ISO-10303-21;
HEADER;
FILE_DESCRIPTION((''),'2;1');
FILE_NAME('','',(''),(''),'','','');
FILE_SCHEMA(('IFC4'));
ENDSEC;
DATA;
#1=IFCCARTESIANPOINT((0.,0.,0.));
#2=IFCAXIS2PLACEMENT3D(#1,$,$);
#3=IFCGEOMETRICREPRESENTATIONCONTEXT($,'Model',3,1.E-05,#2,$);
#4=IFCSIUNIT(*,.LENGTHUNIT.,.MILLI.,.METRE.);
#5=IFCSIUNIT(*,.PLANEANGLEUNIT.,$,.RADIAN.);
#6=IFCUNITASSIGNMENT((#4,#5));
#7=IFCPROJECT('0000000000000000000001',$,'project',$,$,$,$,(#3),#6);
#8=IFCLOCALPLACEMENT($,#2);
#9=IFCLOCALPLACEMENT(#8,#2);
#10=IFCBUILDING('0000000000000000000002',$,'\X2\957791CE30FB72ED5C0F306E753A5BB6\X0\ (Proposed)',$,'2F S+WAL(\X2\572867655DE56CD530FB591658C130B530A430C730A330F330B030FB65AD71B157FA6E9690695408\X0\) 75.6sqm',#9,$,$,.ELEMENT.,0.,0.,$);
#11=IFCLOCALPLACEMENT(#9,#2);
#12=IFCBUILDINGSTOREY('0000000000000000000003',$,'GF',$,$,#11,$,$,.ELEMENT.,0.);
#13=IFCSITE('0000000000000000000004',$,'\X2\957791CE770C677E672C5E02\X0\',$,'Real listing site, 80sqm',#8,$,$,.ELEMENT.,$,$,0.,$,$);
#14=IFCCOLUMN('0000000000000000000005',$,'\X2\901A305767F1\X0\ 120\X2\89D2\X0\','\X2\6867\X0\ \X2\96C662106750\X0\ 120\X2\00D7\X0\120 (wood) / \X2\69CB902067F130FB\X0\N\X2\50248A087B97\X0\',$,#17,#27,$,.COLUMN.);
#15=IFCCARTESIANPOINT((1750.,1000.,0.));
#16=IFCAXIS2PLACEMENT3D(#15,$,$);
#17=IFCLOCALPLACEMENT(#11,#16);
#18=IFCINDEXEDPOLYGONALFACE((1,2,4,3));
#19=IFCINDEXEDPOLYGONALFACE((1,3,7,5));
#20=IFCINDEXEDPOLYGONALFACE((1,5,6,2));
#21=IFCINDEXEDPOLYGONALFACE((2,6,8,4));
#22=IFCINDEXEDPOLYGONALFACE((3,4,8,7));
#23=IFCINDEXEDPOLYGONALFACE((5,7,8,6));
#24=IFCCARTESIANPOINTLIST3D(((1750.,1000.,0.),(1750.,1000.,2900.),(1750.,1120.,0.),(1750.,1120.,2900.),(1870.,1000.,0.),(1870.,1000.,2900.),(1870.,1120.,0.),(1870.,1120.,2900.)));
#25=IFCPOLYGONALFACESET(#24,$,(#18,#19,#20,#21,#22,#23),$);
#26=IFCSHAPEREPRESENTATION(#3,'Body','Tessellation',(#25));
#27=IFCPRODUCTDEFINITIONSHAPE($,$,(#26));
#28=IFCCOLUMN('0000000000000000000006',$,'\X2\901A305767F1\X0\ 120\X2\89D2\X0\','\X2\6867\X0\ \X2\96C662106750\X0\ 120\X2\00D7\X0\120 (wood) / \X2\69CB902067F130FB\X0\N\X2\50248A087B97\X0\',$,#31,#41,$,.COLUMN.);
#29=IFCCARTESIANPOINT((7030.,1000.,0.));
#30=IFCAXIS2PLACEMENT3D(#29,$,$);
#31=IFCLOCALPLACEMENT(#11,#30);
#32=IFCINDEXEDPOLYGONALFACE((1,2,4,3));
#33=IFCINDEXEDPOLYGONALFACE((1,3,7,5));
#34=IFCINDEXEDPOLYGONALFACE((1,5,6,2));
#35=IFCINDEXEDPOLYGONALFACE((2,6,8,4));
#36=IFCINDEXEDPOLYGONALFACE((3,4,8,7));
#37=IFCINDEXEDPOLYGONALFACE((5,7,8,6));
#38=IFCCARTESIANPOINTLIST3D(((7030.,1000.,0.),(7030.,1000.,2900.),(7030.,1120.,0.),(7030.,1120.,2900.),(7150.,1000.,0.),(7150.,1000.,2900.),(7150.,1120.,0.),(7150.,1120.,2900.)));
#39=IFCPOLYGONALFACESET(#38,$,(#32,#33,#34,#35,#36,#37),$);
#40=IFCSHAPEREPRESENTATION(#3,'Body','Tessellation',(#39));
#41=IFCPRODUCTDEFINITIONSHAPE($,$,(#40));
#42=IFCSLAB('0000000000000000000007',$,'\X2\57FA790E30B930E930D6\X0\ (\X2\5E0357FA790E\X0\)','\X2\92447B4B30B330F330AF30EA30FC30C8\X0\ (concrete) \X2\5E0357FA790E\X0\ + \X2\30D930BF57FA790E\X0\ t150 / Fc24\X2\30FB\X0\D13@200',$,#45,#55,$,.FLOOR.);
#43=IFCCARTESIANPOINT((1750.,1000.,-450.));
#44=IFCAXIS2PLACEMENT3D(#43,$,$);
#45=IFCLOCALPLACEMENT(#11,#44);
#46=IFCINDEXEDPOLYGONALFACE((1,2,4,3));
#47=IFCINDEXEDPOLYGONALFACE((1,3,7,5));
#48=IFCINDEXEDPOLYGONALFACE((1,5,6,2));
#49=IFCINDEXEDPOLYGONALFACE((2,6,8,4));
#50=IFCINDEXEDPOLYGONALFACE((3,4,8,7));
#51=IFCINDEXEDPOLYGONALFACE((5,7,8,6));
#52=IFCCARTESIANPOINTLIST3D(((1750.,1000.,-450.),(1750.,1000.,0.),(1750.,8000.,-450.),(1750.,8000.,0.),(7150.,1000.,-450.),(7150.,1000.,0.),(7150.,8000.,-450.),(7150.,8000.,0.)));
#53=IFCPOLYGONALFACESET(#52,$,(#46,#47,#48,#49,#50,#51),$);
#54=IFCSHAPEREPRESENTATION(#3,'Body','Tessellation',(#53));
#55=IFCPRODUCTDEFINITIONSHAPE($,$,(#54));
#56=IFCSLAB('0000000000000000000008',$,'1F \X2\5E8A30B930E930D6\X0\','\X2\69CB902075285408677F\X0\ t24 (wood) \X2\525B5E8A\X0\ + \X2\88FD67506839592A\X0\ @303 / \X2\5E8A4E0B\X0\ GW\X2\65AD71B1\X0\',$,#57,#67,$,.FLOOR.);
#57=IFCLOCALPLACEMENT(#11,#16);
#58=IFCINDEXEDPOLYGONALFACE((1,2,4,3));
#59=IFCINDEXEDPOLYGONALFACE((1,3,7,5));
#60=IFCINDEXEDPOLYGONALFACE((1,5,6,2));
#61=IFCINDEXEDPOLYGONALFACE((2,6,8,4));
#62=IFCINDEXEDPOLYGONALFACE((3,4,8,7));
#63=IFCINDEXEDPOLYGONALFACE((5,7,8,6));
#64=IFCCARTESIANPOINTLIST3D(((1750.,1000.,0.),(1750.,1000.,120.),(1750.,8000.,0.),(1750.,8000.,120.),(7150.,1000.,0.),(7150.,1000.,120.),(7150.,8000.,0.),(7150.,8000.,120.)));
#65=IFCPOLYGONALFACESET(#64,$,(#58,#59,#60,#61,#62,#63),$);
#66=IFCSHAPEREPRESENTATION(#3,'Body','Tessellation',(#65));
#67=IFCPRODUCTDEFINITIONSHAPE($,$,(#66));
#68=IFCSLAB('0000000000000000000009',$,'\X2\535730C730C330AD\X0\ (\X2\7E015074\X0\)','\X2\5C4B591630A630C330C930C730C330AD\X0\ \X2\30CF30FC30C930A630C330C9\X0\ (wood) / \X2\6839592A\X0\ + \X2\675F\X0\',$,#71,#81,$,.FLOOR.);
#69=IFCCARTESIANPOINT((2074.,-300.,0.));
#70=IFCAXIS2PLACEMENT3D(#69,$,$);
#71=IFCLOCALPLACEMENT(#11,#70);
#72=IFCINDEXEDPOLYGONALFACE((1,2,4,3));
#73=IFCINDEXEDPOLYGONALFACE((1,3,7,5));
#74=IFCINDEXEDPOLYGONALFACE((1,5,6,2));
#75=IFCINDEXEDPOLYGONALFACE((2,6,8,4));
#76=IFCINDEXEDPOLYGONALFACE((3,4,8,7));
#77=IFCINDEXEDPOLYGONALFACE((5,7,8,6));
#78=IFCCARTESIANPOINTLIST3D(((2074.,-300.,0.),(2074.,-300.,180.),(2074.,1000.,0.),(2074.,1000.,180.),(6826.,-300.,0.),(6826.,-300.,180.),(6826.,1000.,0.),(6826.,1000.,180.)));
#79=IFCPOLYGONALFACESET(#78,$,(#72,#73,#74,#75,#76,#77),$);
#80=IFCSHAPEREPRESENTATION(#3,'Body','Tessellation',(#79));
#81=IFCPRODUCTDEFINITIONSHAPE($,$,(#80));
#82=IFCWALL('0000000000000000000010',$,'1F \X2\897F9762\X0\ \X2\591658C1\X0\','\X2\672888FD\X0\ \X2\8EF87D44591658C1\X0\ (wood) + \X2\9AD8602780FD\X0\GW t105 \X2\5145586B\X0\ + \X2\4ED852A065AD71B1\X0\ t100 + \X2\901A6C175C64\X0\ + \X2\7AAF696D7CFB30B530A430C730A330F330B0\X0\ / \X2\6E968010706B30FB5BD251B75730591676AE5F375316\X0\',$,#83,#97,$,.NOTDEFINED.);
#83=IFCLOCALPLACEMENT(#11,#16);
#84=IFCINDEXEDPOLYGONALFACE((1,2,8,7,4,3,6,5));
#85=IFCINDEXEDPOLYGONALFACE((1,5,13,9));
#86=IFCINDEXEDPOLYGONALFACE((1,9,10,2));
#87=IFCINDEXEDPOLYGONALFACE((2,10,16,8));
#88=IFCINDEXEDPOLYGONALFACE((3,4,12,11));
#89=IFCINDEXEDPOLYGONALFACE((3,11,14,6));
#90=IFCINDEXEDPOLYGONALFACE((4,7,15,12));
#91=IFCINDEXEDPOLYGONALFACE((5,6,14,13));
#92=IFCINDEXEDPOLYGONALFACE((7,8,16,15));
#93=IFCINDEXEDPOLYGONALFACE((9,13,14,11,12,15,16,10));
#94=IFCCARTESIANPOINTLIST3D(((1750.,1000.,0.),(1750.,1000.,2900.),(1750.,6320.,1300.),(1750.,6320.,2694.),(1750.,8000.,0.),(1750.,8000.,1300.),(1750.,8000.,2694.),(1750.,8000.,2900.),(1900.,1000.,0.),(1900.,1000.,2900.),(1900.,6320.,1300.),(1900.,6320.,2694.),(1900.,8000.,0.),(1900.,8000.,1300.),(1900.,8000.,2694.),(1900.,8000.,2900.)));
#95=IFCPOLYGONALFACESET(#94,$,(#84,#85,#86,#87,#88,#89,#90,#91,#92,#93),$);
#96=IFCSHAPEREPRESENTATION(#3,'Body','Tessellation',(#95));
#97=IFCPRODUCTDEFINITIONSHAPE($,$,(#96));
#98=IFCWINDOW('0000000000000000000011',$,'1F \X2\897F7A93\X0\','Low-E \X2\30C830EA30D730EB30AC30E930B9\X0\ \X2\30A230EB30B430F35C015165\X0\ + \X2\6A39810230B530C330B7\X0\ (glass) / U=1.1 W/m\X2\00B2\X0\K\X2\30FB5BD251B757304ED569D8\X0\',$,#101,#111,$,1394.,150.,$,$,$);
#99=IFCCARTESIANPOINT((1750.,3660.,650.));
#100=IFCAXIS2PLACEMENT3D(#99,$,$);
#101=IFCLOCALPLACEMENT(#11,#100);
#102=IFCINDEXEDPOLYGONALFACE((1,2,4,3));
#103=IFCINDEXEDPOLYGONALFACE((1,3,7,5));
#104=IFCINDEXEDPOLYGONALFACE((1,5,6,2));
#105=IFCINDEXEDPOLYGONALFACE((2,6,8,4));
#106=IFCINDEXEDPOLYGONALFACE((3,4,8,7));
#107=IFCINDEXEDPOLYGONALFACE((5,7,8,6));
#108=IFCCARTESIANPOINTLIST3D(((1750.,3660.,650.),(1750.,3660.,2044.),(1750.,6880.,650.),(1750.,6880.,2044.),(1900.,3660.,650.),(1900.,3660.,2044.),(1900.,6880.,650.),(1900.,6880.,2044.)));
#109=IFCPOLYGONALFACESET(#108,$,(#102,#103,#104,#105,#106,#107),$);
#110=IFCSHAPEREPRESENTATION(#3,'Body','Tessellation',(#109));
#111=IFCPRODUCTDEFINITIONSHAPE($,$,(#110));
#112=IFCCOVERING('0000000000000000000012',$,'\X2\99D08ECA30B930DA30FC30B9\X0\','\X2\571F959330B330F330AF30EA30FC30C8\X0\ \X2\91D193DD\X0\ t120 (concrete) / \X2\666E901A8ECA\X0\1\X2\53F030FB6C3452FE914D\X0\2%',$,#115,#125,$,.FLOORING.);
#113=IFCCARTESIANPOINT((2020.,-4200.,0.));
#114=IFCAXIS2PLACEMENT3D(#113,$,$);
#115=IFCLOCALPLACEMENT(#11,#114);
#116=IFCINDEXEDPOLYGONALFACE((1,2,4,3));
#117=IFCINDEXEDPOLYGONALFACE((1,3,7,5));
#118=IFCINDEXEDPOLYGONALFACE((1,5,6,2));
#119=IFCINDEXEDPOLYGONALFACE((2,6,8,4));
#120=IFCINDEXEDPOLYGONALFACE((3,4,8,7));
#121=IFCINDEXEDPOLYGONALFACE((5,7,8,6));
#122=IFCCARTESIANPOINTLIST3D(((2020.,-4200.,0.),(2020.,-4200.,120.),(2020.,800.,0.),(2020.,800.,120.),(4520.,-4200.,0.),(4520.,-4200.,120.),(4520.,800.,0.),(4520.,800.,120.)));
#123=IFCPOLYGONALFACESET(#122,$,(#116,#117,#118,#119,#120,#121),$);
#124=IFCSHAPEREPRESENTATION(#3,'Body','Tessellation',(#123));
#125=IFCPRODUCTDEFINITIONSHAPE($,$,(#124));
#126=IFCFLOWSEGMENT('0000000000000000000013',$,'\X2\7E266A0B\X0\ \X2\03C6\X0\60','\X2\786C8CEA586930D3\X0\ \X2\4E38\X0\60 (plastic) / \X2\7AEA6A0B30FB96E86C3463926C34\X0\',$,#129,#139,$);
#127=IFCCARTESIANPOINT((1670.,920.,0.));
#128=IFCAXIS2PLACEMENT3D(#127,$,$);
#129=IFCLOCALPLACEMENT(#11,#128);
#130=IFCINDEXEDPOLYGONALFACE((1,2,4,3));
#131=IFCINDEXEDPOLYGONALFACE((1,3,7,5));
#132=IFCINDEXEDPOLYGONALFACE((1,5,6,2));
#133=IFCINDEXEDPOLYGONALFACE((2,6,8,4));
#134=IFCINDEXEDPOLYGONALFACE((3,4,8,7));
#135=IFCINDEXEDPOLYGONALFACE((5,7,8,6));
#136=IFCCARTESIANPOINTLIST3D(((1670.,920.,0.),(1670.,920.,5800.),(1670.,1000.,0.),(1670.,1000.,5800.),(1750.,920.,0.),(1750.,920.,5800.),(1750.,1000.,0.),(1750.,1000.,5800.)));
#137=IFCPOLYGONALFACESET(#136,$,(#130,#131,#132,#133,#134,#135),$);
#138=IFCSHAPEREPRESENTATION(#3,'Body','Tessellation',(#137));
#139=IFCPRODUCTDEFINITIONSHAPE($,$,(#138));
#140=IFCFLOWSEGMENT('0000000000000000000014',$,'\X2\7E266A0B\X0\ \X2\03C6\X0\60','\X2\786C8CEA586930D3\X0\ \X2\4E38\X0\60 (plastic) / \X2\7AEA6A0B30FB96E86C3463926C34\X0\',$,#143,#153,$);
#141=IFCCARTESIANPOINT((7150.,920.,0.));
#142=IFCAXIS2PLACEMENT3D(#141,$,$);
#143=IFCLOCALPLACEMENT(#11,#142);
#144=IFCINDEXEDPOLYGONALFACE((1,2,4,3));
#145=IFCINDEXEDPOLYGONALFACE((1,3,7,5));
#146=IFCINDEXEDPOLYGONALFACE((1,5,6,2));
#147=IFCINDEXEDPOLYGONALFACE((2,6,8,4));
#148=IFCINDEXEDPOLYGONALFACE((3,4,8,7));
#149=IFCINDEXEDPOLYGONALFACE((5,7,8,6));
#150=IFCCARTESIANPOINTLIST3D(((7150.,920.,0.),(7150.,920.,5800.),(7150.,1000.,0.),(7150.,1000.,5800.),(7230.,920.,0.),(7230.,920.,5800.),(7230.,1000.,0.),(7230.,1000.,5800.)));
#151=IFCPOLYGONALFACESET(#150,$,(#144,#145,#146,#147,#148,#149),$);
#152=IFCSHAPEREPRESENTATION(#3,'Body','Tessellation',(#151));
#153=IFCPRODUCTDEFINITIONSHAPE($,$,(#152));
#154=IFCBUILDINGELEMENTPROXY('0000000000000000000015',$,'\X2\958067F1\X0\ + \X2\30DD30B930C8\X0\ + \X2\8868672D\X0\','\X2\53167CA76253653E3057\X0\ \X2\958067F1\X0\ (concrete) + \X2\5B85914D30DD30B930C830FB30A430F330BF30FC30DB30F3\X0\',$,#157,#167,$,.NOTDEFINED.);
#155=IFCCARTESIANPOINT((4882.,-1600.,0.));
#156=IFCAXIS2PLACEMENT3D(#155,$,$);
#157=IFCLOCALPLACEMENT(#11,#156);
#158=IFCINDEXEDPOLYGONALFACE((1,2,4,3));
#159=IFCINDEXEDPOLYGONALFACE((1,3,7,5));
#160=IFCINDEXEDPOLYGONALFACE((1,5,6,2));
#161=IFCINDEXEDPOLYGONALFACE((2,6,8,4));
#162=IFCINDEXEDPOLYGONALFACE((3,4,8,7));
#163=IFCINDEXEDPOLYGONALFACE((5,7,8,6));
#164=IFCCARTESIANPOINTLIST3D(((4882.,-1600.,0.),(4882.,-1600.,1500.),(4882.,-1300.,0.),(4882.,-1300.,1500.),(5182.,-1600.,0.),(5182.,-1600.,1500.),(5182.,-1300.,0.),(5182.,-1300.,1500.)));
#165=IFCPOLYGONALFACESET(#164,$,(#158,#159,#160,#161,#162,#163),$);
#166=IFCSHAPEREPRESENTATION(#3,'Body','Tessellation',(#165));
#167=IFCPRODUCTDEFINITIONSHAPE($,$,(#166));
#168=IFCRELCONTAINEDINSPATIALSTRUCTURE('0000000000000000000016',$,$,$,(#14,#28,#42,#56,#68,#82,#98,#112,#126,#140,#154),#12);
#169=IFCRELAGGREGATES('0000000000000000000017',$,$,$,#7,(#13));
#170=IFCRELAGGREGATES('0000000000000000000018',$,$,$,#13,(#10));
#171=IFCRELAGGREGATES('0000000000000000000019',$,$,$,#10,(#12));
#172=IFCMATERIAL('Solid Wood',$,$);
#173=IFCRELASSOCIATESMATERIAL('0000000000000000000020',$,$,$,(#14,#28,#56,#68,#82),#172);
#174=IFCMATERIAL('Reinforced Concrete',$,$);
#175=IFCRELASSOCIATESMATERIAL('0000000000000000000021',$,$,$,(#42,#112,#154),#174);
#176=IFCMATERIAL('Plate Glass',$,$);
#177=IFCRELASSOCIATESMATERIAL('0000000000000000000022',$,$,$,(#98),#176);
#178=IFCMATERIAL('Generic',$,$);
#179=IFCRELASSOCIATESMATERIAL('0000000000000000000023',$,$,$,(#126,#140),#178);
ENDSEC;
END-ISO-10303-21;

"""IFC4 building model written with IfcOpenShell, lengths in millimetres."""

from ifc_helpers import new_model, si_unit, frame, frame_2d, origin, place, context, project, spatial, rectangle, extrude, material, element, fill, save


model = new_model("IFC4")

# Units and contexts
model_context = context("Model", 3, precision=1e-05, world=origin())
ifc_project = project(units=[si_unit("LENGTHUNIT", "METRE", prefix="MILLI"), si_unit("PLANEANGLEUNIT", "RADIAN")], contexts=[model_context])

# Site, building, storey
site_placement = place(None, origin())
site = spatial("IfcSite", under=ifc_project, at=site_placement, Name="長野県松本市", ObjectType="Real listing site, 80sqm", CompositionType="ELEMENT", RefElevation=0.0)
building_placement = place(site_placement, origin())
building = spatial("IfcBuilding", under=site, at=building_placement, Name="長野・狭小の町家 (Proposed)", ObjectType="2F S+WAL(在来工法・外壁サイディング・断熱基準適合) 75.6sqm", CompositionType="ELEMENT", ElevationOfRefHeight=0.0, ElevationOfTerrain=0.0)
storey_placement = place(building_placement, origin())
storey = spatial("IfcBuildingStorey", under=building, at=storey_placement, Name="GF", CompositionType="ELEMENT", Elevation=0.0)

# Columns
ifc_material_1 = material(Name="Solid Wood")
column_1_placement = place(storey_placement, frame((1750.0, 1000.0, 0.0)))
element("IfcColumn", 1, at=column_1_placement, inside=storey, material=ifc_material_1, Name="通し柱 120角", Description="桧 集成材 120×120 (wood) / 構造柱・N値計算", PredefinedType="COLUMN", context=model_context, shape_type="SweptSolid", body=[
    extrude(rectangle(XDim=120.0, YDim=120.0, at=frame_2d((60.0, 60.0))), frame((1750.0, 1000.0, 0.0)), (0.0, 0.0, 1.0), 2900.0),
])
column_2_placement = place(storey_placement, frame((7030.0, 1000.0, 0.0)))
element("IfcColumn", 2, at=column_2_placement, inside=storey, material=ifc_material_1, Name="通し柱 120角", Description="桧 集成材 120×120 (wood) / 構造柱・N値計算", PredefinedType="COLUMN", context=model_context, shape_type="SweptSolid", body=[
    extrude(rectangle(XDim=120.0, YDim=120.0, at=frame_2d((60.0, 60.0))), frame((7030.0, 1000.0, 0.0)), (0.0, 0.0, 1.0), 2900.0),
])

# Slabs
ifc_material_2 = material(Name="Reinforced Concrete")
slab_1_placement = place(storey_placement, frame((1750.0, 1000.0, -450.0)))
element("IfcSlab", 3, at=slab_1_placement, inside=storey, material=ifc_material_2, Name="基礎スラブ (布基礎)", Description="鉄筋コンクリート (concrete) 布基礎 + ベタ基礎 t150 / Fc24・D13@200", PredefinedType="FLOOR", context=model_context, shape_type="SweptSolid", body=[
    extrude(rectangle(XDim=5400.0, YDim=7000.0, at=frame_2d((2700.0, 3500.0))), frame((1750.0, 1000.0, -450.0)), (0.0, 0.0, 1.0), 450.0),
])
slab_2_placement = place(storey_placement, frame((1750.0, 1000.0, 0.0)))
element("IfcSlab", 4, at=slab_2_placement, inside=storey, material=ifc_material_1, Name="1F 床スラブ", Description="構造用合板 t24 (wood) 剛床 + 製材根太 @303 / 床下 GW断熱", PredefinedType="FLOOR", context=model_context, shape_type="SweptSolid", body=[
    extrude(rectangle(XDim=5400.0, YDim=7000.0, at=frame_2d((2700.0, 3500.0))), frame((1750.0, 1000.0, 0.0)), (0.0, 0.0, 1.0), 120.0),
])
slab_3_placement = place(storey_placement, frame((2074.0, -300.0, 0.0)))
element("IfcSlab", 5, at=slab_3_placement, inside=storey, material=ifc_material_1, Name="南デッキ (縁側)", Description="屋外ウッドデッキ ハードウッド (wood) / 根太 + 束", PredefinedType="FLOOR", context=model_context, shape_type="SweptSolid", body=[
    extrude(rectangle(XDim=4752.0, YDim=1300.0, at=frame_2d((2376.0, 650.0))), frame((2074.0, -300.0, 0.0)), (0.0, 0.0, 1.0), 180.0),
])

# Shared definitions
ifc_material_3 = material(Name="Plate Glass")

# Wall, opening, window
wall_1_placement = place(storey_placement, frame((1750.0, 1000.0, 0.0)))
wall_1 = element("IfcWall", 6, at=wall_1_placement, inside=storey, material=ifc_material_1, Name="1F 西面 外壁", Description="木製 軸組外壁 (wood) + 高性能GW t105 充填 + 付加断熱 t100 + 通気層 + 窯業系サイディング / 準耐火・寒冷地外皮強化", PredefinedType="NOTDEFINED", context=model_context, shape_type="SweptSolid", body=[
    extrude(rectangle(XDim=150.0, YDim=7000.0, at=frame_2d((75.0, 3500.0))), frame((1750.0, 1000.0, 0.0)), (0.0, 0.0, 1.0), 2900.0),
])
opening_1_placement = place(storey_placement, frame((1750.0, 3660.0, 650.0)))
opening_1 = element("IfcOpeningElement", 7, at=opening_1_placement, cuts=wall_1, PredefinedType="NOTDEFINED", context=model_context, shape_type="SweptSolid", body=[
    extrude(rectangle(XDim=150.0, YDim=3220.0, at=frame_2d((75.0, 1610.0))), frame((1750.0, 3660.0, 650.0)), (0.0, 0.0, 1.0), 1394.0),
])
window_1_placement = place(storey_placement, frame((1750.0, 3660.0, 650.0)))
window_1 = element("IfcWindow", 8, at=window_1_placement, inside=storey, material=ifc_material_3, Name="1F 西窓", Description="Low-E トリプルガラス アルゴン封入 + 樹脂サッシ (glass) / U=1.1 W/m²K・寒冷地仕様", OverallHeight=1394.0, OverallWidth=150.0, context=model_context, shape_type="SweptSolid", body=[
    extrude(rectangle(XDim=150.0, YDim=3220.0, at=frame_2d((75.0, 1610.0))), frame((1750.0, 3660.0, 650.0)), (0.0, 0.0, 1.0), 1394.0),
])
fill(opening_1, window_1)

# Covering
covering_1_placement = place(storey_placement, frame((2020.0, -4200.0, 0.0)))
element("IfcCovering", 9, at=covering_1_placement, inside=storey, material=ifc_material_2, Name="駐車スペース", Description="土間コンクリート 金鏝 t120 (concrete) / 普通車1台・水勾配2%", PredefinedType="FLOORING", context=model_context, shape_type="SweptSolid", body=[
    extrude(rectangle(XDim=2500.0, YDim=5000.0, at=frame_2d((1250.0, 2500.0))), frame((2020.0, -4200.0, 0.0)), (0.0, 0.0, 1.0), 120.0),
])

# Flow segments
ifc_material_4 = material(Name="Generic")
flow_segment_1_placement = place(storey_placement, frame((1670.0, 920.0, 0.0)))
element("IfcFlowSegment", 10, at=flow_segment_1_placement, inside=storey, material=ifc_material_4, Name="縦樋 φ60", Description="硬質塩ビ 丸60 (plastic) / 竪樋・雨水排水", context=model_context, shape_type="SweptSolid", body=[
    extrude(rectangle(XDim=80.0, YDim=80.0, at=frame_2d((40.0, 40.0))), frame((1670.0, 920.0, 0.0)), (0.0, 0.0, 1.0), 5800.0),
])
flow_segment_2_placement = place(storey_placement, frame((7150.0, 920.0, 0.0)))
element("IfcFlowSegment", 11, at=flow_segment_2_placement, inside=storey, material=ifc_material_4, Name="縦樋 φ60", Description="硬質塩ビ 丸60 (plastic) / 竪樋・雨水排水", context=model_context, shape_type="SweptSolid", body=[
    extrude(rectangle(XDim=80.0, YDim=80.0, at=frame_2d((40.0, 40.0))), frame((7150.0, 920.0, 0.0)), (0.0, 0.0, 1.0), 5800.0),
])

# Building element proxy
proxy_placement = place(storey_placement, frame((4882.0, -1600.0, 0.0)))
element("IfcBuildingElementProxy", 12, at=proxy_placement, inside=storey, material=ifc_material_2, Name="門柱 + ポスト + 表札", Description="化粧打放し 門柱 (concrete) + 宅配ポスト・インターホン", PredefinedType="NOTDEFINED", context=model_context, shape_type="SweptSolid", body=[
    extrude(rectangle(XDim=300.0, YDim=300.0, at=frame_2d((150.0, 150.0))), frame((4882.0, -1600.0, 0.0)), (0.0, 0.0, 1.0), 1500.0),
])

save(model, "model.ifc")
